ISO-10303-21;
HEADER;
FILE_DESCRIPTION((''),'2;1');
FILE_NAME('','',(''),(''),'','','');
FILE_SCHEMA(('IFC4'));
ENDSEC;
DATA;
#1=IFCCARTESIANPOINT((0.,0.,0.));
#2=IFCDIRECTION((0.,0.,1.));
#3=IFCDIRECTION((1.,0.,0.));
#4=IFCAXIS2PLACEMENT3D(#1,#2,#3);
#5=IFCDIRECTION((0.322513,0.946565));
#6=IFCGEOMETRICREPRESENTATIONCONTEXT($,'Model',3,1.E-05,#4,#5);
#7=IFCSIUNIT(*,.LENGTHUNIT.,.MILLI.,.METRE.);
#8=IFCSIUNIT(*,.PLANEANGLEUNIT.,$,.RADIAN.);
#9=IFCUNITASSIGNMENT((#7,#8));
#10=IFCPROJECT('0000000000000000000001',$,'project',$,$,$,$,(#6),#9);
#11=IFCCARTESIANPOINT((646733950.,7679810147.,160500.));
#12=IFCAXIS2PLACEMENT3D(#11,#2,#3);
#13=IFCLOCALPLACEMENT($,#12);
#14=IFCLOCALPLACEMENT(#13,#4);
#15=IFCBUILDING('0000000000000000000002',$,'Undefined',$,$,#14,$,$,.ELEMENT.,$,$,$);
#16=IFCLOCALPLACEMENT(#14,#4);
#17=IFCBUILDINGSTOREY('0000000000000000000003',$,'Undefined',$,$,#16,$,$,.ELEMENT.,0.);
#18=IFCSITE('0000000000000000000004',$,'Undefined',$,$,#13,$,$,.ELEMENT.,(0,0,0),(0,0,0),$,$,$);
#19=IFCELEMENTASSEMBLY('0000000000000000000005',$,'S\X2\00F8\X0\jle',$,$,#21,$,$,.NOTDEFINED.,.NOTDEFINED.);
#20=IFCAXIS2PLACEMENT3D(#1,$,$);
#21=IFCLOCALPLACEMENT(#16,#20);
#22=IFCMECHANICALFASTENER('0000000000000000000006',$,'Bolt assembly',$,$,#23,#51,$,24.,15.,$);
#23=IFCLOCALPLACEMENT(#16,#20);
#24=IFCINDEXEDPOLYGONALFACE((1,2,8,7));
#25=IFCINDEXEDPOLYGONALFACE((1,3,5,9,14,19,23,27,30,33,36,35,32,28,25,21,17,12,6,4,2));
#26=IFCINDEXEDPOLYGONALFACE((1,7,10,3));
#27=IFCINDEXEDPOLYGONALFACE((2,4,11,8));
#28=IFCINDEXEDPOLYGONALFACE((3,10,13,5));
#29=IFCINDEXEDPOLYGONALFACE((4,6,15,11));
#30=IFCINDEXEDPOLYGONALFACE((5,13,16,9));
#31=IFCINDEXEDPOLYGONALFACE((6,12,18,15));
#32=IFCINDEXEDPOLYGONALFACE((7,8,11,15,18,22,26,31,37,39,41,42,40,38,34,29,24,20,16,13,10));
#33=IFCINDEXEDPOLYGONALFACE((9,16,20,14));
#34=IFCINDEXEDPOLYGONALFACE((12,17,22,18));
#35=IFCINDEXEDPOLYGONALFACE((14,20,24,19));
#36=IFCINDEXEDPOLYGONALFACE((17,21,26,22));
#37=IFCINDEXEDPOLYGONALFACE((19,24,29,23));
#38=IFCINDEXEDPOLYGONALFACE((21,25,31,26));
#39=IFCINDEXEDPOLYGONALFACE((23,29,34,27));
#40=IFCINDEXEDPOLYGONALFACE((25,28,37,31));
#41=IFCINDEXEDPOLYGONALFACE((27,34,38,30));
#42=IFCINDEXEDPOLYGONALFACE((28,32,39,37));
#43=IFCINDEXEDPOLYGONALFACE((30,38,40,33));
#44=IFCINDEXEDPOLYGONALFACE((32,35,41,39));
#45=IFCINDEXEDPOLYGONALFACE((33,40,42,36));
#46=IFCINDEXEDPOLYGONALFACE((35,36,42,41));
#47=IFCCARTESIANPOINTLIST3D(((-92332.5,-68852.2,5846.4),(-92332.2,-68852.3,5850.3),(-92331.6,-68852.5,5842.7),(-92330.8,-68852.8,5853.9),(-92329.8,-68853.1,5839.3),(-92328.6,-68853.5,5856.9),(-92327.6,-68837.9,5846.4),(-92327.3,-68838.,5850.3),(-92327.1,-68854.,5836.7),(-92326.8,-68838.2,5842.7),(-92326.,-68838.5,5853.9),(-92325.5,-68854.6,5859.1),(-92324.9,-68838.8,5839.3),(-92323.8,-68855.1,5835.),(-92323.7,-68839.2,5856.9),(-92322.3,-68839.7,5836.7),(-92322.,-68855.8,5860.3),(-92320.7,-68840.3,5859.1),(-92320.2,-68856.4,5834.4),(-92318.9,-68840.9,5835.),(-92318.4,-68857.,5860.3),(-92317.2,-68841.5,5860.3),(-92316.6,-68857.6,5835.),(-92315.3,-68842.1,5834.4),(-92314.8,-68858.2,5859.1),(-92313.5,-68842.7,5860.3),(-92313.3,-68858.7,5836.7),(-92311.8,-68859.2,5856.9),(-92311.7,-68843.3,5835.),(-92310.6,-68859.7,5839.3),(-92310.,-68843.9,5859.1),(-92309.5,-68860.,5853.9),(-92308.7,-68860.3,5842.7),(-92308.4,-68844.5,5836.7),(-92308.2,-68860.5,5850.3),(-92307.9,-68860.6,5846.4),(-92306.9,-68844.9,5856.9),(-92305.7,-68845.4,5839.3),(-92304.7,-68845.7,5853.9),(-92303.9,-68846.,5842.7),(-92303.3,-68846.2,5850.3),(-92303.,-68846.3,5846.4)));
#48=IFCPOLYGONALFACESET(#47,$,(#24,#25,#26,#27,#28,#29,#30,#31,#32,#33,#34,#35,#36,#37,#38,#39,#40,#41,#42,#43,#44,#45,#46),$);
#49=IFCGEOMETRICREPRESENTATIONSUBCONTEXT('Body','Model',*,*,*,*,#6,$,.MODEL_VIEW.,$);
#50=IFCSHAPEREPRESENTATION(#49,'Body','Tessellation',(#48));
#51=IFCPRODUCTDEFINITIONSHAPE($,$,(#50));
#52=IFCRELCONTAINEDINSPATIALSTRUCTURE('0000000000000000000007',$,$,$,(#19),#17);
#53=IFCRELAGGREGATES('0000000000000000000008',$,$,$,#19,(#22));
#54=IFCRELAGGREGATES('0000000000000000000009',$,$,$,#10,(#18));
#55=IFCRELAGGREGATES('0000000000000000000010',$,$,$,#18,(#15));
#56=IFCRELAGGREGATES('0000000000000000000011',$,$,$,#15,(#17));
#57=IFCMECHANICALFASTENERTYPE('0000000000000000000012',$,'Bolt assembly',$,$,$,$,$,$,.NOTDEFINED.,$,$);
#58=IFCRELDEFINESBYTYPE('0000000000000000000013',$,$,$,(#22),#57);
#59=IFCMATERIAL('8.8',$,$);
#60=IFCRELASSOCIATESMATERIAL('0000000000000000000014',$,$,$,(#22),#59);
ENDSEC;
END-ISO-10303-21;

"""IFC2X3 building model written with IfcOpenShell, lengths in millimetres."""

from ifc_helpers import new_model, si_unit, direction, frame, origin_with_axes, origin_2d_with_axis, place, context, subcontext, project, spatial, circle, extrude, source, transform, mapped, material, type_object, element, aggregate, save


model = new_model("IFC2X3")

# Units and contexts
model_context = context("Model", 3, precision=1e-05, world=origin_with_axes(), true_north=direction((0.322513, 0.946565)))
body_context = subcontext(model_context, "Body", "Model", "MODEL_VIEW")
ifc_project = project(units=[si_unit("LENGTHUNIT", "METRE", prefix="MILLI"), si_unit("PLANEANGLEUNIT", "RADIAN")], contexts=[model_context])

# Site, building, storey
site_placement = place(None, frame((646733950.0, 7679810147.0, 160500.0), z_axis=(0.0, 0.0, 1.0), x_axis=(1.0, 0.0, 0.0)))
site = spatial("IfcSite", under=ifc_project, at=site_placement, Name="Undefined", CompositionType="ELEMENT", RefLatitude=(0, 0, 0), RefLongitude=(0, 0, 0))
building_placement = place(site_placement, origin_with_axes())
building = spatial("IfcBuilding", under=site, at=building_placement, Name="Undefined", CompositionType="ELEMENT")
storey_placement = place(building_placement, origin_with_axes())
storey = spatial("IfcBuildingStorey", under=building, at=storey_placement, Name="Undefined", CompositionType="ELEMENT", Elevation=0.0)

# Element assembly
assembly_1_placement = place(storey_placement, origin_with_axes())
assembly_1 = element("IfcElementAssembly", 1, at=assembly_1_placement, inside=storey, Name="Søjle", AssemblyPlace="NOTDEFINED", PredefinedType="NOTDEFINED")

# Mechanical fastener
ifc_material_1 = material(Name="8.8")
mechanical_fastener_type = type_object("IfcMechanicalFastenerType", Name="Bolt assembly")
shared_shape_1 = source(origin_with_axes(), body_context, "Body", "SweptSolid", [
    extrude(circle(Radius=13.0, at=origin_2d_with_axis()), frame((0.0, -7.5, 0.0), z_axis=(0.0, 1.0, 0.0), x_axis=(1.0, 0.0, 0.0)), (0.0, 0.0, 1.0), 15.1),
])
mechanical_fastener_1_placement = place(assembly_1_placement, frame((-92317.8, -68849.3, 5847.4), z_axis=(0.946565, -0.322513, 0.0), x_axis=(0.0, 0.0, -1.0)))
mechanical_fastener_1 = element("IfcMechanicalFastener", 2, at=mechanical_fastener_1_placement, type_object=mechanical_fastener_type, material=ifc_material_1, Name="Bolt assembly", NominalDiameter=24.0, NominalLength=15.0, context=body_context, shape_type="MappedRepresentation", body=[
    mapped(shared_shape_1, transform((0.0, 0.0, 0.0))),
])
aggregate(assembly_1, [mechanical_fastener_1])

save(model, "model.ifc")
